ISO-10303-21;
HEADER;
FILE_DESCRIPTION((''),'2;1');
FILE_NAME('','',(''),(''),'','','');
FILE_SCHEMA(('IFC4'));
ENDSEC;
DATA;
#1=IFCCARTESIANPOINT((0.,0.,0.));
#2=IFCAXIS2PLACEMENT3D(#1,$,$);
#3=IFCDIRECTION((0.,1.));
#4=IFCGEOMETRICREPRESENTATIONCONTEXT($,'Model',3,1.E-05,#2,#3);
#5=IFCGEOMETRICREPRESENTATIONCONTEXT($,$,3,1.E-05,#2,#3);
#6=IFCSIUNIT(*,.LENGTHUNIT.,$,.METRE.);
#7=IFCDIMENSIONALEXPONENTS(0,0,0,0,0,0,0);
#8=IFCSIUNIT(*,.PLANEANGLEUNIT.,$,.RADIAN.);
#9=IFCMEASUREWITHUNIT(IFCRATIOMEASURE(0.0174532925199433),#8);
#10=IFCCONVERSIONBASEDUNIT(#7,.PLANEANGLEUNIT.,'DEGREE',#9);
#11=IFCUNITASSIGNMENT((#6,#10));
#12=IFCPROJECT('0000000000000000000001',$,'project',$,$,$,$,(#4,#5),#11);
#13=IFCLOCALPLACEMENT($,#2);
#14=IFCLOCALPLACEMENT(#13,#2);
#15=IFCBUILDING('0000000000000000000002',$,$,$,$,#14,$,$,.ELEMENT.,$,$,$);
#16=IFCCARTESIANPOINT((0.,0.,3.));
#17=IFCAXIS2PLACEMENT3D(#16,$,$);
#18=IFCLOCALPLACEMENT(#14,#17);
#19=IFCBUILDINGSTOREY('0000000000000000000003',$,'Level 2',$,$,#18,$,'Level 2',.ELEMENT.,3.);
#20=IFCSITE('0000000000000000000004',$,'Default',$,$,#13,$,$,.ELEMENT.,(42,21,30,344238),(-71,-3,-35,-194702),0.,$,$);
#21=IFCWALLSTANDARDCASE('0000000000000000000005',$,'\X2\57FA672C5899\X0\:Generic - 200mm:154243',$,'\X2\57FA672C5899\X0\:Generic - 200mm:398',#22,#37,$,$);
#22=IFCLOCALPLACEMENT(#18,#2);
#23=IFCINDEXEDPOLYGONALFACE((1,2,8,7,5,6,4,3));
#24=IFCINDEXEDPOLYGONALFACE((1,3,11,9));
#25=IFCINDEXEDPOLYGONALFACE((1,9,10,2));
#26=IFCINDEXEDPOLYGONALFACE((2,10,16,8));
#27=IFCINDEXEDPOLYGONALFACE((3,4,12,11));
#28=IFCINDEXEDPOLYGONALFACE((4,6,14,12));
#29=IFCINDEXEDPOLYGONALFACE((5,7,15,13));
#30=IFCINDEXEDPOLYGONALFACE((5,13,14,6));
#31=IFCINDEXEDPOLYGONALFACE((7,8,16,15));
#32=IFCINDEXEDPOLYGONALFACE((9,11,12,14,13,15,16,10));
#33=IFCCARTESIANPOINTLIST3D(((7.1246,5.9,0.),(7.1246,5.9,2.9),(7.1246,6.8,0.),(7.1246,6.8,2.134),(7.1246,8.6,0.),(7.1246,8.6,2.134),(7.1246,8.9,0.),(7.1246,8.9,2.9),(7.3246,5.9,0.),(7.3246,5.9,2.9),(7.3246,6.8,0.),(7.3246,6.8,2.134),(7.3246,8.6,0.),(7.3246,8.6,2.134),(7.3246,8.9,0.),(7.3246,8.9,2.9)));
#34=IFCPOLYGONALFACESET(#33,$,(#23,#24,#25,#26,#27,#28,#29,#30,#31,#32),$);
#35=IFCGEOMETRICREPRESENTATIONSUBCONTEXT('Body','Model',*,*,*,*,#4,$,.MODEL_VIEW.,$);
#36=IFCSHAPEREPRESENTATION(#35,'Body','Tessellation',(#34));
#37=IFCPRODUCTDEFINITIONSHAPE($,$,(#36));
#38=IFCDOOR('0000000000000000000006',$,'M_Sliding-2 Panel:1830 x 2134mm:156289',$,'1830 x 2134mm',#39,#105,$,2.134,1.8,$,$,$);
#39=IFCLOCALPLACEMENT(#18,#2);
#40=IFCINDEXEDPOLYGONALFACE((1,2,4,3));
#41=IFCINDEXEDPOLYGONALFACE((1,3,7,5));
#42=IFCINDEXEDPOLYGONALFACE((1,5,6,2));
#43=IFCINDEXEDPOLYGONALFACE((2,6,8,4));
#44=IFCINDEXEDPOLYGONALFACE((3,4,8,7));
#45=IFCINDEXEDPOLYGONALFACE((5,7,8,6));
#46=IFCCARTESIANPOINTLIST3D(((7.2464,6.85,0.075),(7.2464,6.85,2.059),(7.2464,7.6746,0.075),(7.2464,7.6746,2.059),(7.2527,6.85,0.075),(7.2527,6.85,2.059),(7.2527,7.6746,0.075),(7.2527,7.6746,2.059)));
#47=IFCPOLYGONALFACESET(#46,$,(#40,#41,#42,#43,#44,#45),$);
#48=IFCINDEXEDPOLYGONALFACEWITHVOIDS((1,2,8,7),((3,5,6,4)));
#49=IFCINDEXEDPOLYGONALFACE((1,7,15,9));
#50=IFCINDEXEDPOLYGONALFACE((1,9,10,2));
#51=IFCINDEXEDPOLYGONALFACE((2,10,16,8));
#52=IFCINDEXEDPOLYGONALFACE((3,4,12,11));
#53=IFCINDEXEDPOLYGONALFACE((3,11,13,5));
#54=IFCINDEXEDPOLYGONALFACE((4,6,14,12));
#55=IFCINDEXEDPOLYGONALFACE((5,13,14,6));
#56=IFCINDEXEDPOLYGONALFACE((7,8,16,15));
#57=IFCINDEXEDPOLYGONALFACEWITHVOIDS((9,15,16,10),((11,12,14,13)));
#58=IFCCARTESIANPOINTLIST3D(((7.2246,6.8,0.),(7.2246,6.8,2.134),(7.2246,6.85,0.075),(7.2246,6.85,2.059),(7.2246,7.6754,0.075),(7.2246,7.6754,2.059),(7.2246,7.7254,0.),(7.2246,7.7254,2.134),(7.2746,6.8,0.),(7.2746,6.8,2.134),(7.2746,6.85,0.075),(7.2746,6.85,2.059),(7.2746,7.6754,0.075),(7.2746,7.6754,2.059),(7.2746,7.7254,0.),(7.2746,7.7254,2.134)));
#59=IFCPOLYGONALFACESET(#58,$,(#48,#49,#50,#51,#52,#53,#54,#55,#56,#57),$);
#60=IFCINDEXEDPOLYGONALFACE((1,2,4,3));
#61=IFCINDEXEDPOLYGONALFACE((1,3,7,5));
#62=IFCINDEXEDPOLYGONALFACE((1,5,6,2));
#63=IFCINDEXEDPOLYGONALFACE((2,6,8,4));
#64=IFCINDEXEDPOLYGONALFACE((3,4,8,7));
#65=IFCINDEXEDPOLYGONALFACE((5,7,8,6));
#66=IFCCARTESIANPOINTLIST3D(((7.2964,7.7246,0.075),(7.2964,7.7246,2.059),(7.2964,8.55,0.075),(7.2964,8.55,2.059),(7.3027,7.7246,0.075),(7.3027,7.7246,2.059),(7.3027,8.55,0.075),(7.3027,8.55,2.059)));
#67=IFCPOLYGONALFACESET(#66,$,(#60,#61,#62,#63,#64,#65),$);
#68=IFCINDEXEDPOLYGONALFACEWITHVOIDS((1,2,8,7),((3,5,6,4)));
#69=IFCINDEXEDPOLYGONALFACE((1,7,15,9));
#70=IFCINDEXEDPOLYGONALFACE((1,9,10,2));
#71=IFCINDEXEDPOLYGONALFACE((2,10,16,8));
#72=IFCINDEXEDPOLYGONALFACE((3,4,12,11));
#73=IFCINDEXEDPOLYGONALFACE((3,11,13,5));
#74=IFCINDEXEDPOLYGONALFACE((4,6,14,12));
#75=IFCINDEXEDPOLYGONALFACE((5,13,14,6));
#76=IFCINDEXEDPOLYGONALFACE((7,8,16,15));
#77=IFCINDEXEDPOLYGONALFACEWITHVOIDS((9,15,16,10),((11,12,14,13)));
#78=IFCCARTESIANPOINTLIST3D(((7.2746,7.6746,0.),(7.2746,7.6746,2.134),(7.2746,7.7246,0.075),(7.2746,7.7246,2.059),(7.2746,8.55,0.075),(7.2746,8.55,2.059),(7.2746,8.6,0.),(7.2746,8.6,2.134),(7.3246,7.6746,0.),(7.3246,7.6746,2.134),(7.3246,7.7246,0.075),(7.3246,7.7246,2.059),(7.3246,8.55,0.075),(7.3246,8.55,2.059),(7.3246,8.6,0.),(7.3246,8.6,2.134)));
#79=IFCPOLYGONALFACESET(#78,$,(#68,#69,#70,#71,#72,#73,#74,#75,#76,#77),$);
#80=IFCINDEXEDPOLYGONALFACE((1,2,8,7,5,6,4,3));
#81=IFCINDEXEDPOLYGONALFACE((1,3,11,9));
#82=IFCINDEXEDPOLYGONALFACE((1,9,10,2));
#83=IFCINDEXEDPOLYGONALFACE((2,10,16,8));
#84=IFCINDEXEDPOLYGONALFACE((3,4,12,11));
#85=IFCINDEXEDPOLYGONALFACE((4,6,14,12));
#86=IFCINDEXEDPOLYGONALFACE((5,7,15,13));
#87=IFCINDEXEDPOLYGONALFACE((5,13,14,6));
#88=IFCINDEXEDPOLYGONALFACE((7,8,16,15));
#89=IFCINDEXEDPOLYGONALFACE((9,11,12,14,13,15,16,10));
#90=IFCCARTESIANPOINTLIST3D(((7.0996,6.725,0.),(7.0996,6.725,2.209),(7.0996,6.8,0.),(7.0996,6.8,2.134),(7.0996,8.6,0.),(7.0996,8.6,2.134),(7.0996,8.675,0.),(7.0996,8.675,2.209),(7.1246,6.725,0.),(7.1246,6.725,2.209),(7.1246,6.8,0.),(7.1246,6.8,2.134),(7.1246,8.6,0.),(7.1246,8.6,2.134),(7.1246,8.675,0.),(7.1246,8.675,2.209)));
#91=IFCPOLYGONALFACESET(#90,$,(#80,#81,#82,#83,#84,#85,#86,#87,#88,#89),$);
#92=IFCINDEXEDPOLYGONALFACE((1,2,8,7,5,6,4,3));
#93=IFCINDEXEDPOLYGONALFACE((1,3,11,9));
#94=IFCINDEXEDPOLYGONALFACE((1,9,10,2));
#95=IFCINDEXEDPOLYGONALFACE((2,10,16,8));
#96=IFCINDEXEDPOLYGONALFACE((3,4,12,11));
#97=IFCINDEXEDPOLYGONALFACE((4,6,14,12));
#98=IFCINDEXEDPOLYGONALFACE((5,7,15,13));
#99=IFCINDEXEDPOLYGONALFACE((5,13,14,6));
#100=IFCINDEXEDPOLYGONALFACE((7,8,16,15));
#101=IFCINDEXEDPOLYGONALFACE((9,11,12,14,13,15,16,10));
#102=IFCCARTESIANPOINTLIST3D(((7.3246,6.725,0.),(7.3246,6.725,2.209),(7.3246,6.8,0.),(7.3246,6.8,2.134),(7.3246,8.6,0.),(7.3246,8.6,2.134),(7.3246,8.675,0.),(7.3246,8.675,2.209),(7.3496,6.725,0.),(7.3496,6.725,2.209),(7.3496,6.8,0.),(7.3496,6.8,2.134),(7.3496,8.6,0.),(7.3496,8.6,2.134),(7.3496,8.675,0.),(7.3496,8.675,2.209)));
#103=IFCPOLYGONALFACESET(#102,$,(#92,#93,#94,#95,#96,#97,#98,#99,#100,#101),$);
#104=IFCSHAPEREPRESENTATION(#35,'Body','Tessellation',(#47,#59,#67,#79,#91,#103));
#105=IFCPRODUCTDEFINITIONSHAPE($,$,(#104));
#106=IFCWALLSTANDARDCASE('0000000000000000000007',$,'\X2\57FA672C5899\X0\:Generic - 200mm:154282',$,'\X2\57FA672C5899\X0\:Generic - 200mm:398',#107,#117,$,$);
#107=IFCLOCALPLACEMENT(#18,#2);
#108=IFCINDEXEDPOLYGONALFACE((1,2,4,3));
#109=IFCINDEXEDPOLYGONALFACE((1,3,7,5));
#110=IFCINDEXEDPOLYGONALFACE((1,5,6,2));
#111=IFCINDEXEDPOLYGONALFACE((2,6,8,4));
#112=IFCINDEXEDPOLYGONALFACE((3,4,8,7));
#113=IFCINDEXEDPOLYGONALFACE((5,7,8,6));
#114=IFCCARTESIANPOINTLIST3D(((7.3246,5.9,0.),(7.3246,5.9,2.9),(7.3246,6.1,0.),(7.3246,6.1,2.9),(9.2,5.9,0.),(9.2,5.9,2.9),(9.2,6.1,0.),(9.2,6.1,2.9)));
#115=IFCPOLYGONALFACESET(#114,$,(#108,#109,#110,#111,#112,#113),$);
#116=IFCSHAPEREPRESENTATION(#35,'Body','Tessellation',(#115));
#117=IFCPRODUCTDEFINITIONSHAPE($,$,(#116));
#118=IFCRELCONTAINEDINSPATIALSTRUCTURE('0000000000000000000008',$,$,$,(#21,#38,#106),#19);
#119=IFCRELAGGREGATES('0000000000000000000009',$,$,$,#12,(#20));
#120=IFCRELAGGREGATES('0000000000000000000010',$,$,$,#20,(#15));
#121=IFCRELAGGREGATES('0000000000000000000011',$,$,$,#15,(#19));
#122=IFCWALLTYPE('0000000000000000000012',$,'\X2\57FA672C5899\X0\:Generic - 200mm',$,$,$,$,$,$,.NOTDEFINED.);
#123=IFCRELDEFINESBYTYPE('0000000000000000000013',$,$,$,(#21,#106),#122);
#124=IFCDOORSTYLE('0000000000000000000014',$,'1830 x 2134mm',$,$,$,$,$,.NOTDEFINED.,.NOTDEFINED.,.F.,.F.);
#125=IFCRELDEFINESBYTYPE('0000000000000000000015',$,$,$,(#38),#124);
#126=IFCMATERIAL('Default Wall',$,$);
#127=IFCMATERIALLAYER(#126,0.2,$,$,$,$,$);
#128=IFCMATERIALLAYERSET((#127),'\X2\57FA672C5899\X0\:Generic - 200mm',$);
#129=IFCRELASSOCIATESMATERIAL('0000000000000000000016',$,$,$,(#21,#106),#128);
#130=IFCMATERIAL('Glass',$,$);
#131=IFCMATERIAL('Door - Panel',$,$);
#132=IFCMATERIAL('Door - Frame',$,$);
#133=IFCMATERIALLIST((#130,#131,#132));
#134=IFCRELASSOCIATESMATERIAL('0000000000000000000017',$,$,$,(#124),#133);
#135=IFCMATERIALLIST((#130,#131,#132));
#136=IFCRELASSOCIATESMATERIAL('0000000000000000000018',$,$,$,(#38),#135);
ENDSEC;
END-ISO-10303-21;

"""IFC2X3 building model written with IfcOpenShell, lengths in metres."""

from ifc_helpers import new_model, entity, si_unit, converted_unit, direction, frame, frame_2d, origin, place, context, subcontext, project, spatial, polyline, rectangle, outline, extrude, clip, bounded_halfspace, source, transform, mapped, material, material_list, layer, layer_set, layer_usage, type_object, type_shapes, element, fill, save


model = new_model("IFC2X3")

# Units and contexts
model_context = context("Model", 3, precision=1e-05, world=origin(), true_north=direction((0.0, 1.0)))
context_of_model = context(None, 3, precision=1e-05, world=origin(), true_north=direction((0.0, 1.0)))
body_context = subcontext(model_context, "Body", "Model", "MODEL_VIEW")
ifc_project = project(units=[si_unit("LENGTHUNIT", "METRE"), converted_unit("PLANEANGLEUNIT", "DEGREE", entity("IfcRatioMeasure", 0.0174532925199433), si_unit("PLANEANGLEUNIT", "RADIAN"), dimensions=[0, 0, 0, 0, 0, 0, 0])], contexts=[model_context, context_of_model])

# Site, building, storey
site_placement = place(None, origin())
site = spatial("IfcSite", under=ifc_project, at=site_placement, Name="Default", CompositionType="ELEMENT", RefLatitude=(42, 21, 30, 344238), RefLongitude=(-71, -3, -35, -194702), RefElevation=0.0)
building_placement = place(site_placement, origin())
building = spatial("IfcBuilding", under=site, at=building_placement, CompositionType="ELEMENT")
storey_placement = place(building_placement, frame((0.0, 0.0, 3.0)))
storey = spatial("IfcBuildingStorey", under=building, at=storey_placement, Name="Level 2", LongName="Level 2", CompositionType="ELEMENT", Elevation=3.0)

# Wall, opening, door
ifc_material_1 = material(Name="Default Wall")
ifc_layer_1 = layer(ifc_material_1, 0.2)
ifc_layer_set_1 = layer_set([ifc_layer_1], Name="基本墙:Generic - 200mm")
ifc_layer_usage_1 = layer_usage(ifc_layer_set_1, "AXIS2", "NEGATIVE", 0.1)
wall_type_1 = type_object("IfcWallType", Name="基本墙:Generic - 200mm", PredefinedType="NOTDEFINED")
wall_1_placement = place(storey_placement, frame((7.2246, 8.9, 0.0), z_axis=(0.0, 0.0, 1.0), x_axis=(0.0, -1.0, 0.0)))
wall_1 = element("IfcWallStandardCase", 1, at=wall_1_placement, inside=storey, type_object=wall_type_1, material=ifc_layer_usage_1, Name="基本墙:Generic - 200mm:154243", ObjectType="基本墙:Generic - 200mm:398", context=body_context, shape_type="Clipping", body=[
    clip(extrude(rectangle(XDim=3.0, YDim=0.2, at=frame_2d((1.5, 0.0), x_axis=(-1.0, 0.0))), origin(), (0.0, 0.0, 1.0), 3.2), bounded_halfspace(frame((0.0, -0.1, 2.9), z_axis=(0.0, 0.0, -1.0), x_axis=(1.0, 0.0, 0.0)), True, frame((0.0, -0.1, 2.9), z_axis=(0.0, 0.0, -1.0), x_axis=(1.0, 0.0, 0.0)), polyline([(0.0, 0.0), (0.0, -0.2), (2.8, -0.2), (3.0, -0.2), (3.0, 0.0), (0.0, 0.0)]))),
])
opening_1_placement = place(wall_1_placement, frame((0.3, -0.1, 0.0)))
opening_1 = element("IfcOpeningElement", 2, at=opening_1_placement, cuts=wall_1, ObjectType="Opening", context=body_context, shape_type="SweptSolid", body=[
    extrude(rectangle(XDim=2.134, YDim=1.8, at=frame_2d((1.067, 0.9), x_axis=(-1.0, 0.0))), frame((0.0, 0.0, 0.0), z_axis=(0.0, 1.0, 0.0), x_axis=(0.0, 0.0, 1.0)), (0.0, 0.0, 1.0), 0.2),
])
ifc_material_2 = material(Name="Glass")
ifc_material_3 = material(Name="Door - Panel")
ifc_material_4 = material(Name="Door - Frame")
ifc_material_list_1 = material_list([ifc_material_2, ifc_material_3, ifc_material_4])
ifc_material_list_2 = material_list([ifc_material_2, ifc_material_3, ifc_material_4])
door_style_1 = type_object("IfcDoorStyle", Name="1830 x 2134mm", ConstructionType="NOTDEFINED", OperationType="NOTDEFINED", ParameterTakesPrecedence=False, Sizeable=False, material=ifc_material_list_2)
shared_shape_1 = source(origin(), body_context, "Body", "SweptSolid", [
    extrude(rectangle(XDim=0.0063, YDim=0.8246, at=frame_2d((0.0, 0.0), x_axis=(1.0, 0.0))), frame((1.3377, 0.125, 0.075), z_axis=(0.0, 0.0, 1.0), x_axis=(0.0, -1.0, 0.0)), (0.0, 0.0, 1.0), 1.984),
    extrude(outline(polyline([(-0.4627, -1.067), (0.4627, -1.067), (0.4627, 1.067), (-0.4627, 1.067), (-0.4627, -1.067)]), holes=[polyline([(-0.4127, -0.992), (-0.4127, 0.992), (0.4127, 0.992), (0.4127, -0.992), (-0.4127, -0.992)])]), frame((1.3373, 0.1, 1.067), z_axis=(0.0, 1.0, 0.0), x_axis=(1.0, 0.0, 0.0)), (0.0, 0.0, 1.0), 0.05),
    extrude(rectangle(XDim=0.0063, YDim=0.8254, at=frame_2d((0.0, 0.0), x_axis=(1.0, 0.0))), frame((0.4627, 0.175, 0.075), z_axis=(0.0, 0.0, 1.0), x_axis=(0.0, -1.0, 0.0)), (0.0, 0.0, 1.0), 1.984),
    extrude(outline(polyline([(-1.067, -0.4627), (1.067, -0.4627), (1.067, 0.4627), (-1.067, 0.4627), (-1.067, -0.4627)]), holes=[polyline([(-0.992, -0.4127), (-0.992, 0.4127), (0.992, 0.4127), (0.992, -0.4127), (-0.992, -0.4127)])]), frame((0.4627, 0.15, 1.067), z_axis=(0.0, 1.0, 0.0), x_axis=(0.0, 0.0, -1.0)), (0.0, 0.0, 1.0), 0.05),
    extrude(outline(polyline([(-1.0857, -0.975), (1.1233, -0.975), (1.1233, 0.975), (-1.0857, 0.975), (-1.0857, 0.9), (1.0482, 0.9), (1.0482, -0.9), (-1.0857, -0.9), (-1.0857, -0.975)])), frame((0.9, -0.025, 1.0857), z_axis=(0.0, 1.0, 0.0), x_axis=(0.0, 0.0, 1.0)), (0.0, 0.0, 1.0), 0.025),
    extrude(outline(polyline([(-0.975, -1.0857), (-0.9, -1.0857), (-0.9, 1.0482), (0.9, 1.0482), (0.9, -1.0857), (0.975, -1.0857), (0.975, 1.1233), (-0.975, 1.1233), (-0.975, -1.0857)])), frame((0.9, 0.2, 1.0857), z_axis=(0.0, 1.0, 0.0), x_axis=(-1.0, 0.0, 0.0)), (0.0, 0.0, 1.0), 0.025),
])
type_shapes(door_style_1, [shared_shape_1])
door_1_placement = place(opening_1_placement, origin())
door_1 = element("IfcDoor", 3, at=door_1_placement, inside=storey, type_object=door_style_1, material=ifc_material_list_1, Name="M_Sliding-2 Panel:1830 x 2134mm:156289", ObjectType="1830 x 2134mm", OverallHeight=2.134, OverallWidth=1.8, context=body_context, shape_type="MappedRepresentation", body=[
    mapped(shared_shape_1, transform((0.0, 0.0, 0.0), scale=1.0)),
])
fill(opening_1, door_1)

# Wall
ifc_layer_usage_2 = layer_usage(ifc_layer_set_1, "AXIS2", "NEGATIVE", 0.1)
wall_2_placement = place(storey_placement, frame((7.3246, 6.0, 0.0)))
element("IfcWallStandardCase", 4, at=wall_2_placement, inside=storey, type_object=wall_type_1, material=ifc_layer_usage_2, Name="基本墙:Generic - 200mm:154282", ObjectType="基本墙:Generic - 200mm:398", context=body_context, shape_type="Clipping", body=[
    clip(extrude(rectangle(XDim=1.8754, YDim=0.2, at=frame_2d((0.9377, 0.0), x_axis=(-1.0, 0.0))), origin(), (0.0, 0.0, 1.0), 3.2), bounded_halfspace(frame((0.0, 0.1, 2.9), z_axis=(0.0, 0.0, -1.0), x_axis=(0.0, -1.0, 0.0)), True, frame((0.0, 0.1, 2.9), z_axis=(0.0, 0.0, -1.0), x_axis=(0.0, -1.0, 0.0)), polyline([(0.0, 0.0), (0.0, -1.8754), (0.2, -1.8754), (0.2, -1.6754), (0.2, 0.0), (0.0, 0.0)]))),
])

save(model, "model.ifc")
